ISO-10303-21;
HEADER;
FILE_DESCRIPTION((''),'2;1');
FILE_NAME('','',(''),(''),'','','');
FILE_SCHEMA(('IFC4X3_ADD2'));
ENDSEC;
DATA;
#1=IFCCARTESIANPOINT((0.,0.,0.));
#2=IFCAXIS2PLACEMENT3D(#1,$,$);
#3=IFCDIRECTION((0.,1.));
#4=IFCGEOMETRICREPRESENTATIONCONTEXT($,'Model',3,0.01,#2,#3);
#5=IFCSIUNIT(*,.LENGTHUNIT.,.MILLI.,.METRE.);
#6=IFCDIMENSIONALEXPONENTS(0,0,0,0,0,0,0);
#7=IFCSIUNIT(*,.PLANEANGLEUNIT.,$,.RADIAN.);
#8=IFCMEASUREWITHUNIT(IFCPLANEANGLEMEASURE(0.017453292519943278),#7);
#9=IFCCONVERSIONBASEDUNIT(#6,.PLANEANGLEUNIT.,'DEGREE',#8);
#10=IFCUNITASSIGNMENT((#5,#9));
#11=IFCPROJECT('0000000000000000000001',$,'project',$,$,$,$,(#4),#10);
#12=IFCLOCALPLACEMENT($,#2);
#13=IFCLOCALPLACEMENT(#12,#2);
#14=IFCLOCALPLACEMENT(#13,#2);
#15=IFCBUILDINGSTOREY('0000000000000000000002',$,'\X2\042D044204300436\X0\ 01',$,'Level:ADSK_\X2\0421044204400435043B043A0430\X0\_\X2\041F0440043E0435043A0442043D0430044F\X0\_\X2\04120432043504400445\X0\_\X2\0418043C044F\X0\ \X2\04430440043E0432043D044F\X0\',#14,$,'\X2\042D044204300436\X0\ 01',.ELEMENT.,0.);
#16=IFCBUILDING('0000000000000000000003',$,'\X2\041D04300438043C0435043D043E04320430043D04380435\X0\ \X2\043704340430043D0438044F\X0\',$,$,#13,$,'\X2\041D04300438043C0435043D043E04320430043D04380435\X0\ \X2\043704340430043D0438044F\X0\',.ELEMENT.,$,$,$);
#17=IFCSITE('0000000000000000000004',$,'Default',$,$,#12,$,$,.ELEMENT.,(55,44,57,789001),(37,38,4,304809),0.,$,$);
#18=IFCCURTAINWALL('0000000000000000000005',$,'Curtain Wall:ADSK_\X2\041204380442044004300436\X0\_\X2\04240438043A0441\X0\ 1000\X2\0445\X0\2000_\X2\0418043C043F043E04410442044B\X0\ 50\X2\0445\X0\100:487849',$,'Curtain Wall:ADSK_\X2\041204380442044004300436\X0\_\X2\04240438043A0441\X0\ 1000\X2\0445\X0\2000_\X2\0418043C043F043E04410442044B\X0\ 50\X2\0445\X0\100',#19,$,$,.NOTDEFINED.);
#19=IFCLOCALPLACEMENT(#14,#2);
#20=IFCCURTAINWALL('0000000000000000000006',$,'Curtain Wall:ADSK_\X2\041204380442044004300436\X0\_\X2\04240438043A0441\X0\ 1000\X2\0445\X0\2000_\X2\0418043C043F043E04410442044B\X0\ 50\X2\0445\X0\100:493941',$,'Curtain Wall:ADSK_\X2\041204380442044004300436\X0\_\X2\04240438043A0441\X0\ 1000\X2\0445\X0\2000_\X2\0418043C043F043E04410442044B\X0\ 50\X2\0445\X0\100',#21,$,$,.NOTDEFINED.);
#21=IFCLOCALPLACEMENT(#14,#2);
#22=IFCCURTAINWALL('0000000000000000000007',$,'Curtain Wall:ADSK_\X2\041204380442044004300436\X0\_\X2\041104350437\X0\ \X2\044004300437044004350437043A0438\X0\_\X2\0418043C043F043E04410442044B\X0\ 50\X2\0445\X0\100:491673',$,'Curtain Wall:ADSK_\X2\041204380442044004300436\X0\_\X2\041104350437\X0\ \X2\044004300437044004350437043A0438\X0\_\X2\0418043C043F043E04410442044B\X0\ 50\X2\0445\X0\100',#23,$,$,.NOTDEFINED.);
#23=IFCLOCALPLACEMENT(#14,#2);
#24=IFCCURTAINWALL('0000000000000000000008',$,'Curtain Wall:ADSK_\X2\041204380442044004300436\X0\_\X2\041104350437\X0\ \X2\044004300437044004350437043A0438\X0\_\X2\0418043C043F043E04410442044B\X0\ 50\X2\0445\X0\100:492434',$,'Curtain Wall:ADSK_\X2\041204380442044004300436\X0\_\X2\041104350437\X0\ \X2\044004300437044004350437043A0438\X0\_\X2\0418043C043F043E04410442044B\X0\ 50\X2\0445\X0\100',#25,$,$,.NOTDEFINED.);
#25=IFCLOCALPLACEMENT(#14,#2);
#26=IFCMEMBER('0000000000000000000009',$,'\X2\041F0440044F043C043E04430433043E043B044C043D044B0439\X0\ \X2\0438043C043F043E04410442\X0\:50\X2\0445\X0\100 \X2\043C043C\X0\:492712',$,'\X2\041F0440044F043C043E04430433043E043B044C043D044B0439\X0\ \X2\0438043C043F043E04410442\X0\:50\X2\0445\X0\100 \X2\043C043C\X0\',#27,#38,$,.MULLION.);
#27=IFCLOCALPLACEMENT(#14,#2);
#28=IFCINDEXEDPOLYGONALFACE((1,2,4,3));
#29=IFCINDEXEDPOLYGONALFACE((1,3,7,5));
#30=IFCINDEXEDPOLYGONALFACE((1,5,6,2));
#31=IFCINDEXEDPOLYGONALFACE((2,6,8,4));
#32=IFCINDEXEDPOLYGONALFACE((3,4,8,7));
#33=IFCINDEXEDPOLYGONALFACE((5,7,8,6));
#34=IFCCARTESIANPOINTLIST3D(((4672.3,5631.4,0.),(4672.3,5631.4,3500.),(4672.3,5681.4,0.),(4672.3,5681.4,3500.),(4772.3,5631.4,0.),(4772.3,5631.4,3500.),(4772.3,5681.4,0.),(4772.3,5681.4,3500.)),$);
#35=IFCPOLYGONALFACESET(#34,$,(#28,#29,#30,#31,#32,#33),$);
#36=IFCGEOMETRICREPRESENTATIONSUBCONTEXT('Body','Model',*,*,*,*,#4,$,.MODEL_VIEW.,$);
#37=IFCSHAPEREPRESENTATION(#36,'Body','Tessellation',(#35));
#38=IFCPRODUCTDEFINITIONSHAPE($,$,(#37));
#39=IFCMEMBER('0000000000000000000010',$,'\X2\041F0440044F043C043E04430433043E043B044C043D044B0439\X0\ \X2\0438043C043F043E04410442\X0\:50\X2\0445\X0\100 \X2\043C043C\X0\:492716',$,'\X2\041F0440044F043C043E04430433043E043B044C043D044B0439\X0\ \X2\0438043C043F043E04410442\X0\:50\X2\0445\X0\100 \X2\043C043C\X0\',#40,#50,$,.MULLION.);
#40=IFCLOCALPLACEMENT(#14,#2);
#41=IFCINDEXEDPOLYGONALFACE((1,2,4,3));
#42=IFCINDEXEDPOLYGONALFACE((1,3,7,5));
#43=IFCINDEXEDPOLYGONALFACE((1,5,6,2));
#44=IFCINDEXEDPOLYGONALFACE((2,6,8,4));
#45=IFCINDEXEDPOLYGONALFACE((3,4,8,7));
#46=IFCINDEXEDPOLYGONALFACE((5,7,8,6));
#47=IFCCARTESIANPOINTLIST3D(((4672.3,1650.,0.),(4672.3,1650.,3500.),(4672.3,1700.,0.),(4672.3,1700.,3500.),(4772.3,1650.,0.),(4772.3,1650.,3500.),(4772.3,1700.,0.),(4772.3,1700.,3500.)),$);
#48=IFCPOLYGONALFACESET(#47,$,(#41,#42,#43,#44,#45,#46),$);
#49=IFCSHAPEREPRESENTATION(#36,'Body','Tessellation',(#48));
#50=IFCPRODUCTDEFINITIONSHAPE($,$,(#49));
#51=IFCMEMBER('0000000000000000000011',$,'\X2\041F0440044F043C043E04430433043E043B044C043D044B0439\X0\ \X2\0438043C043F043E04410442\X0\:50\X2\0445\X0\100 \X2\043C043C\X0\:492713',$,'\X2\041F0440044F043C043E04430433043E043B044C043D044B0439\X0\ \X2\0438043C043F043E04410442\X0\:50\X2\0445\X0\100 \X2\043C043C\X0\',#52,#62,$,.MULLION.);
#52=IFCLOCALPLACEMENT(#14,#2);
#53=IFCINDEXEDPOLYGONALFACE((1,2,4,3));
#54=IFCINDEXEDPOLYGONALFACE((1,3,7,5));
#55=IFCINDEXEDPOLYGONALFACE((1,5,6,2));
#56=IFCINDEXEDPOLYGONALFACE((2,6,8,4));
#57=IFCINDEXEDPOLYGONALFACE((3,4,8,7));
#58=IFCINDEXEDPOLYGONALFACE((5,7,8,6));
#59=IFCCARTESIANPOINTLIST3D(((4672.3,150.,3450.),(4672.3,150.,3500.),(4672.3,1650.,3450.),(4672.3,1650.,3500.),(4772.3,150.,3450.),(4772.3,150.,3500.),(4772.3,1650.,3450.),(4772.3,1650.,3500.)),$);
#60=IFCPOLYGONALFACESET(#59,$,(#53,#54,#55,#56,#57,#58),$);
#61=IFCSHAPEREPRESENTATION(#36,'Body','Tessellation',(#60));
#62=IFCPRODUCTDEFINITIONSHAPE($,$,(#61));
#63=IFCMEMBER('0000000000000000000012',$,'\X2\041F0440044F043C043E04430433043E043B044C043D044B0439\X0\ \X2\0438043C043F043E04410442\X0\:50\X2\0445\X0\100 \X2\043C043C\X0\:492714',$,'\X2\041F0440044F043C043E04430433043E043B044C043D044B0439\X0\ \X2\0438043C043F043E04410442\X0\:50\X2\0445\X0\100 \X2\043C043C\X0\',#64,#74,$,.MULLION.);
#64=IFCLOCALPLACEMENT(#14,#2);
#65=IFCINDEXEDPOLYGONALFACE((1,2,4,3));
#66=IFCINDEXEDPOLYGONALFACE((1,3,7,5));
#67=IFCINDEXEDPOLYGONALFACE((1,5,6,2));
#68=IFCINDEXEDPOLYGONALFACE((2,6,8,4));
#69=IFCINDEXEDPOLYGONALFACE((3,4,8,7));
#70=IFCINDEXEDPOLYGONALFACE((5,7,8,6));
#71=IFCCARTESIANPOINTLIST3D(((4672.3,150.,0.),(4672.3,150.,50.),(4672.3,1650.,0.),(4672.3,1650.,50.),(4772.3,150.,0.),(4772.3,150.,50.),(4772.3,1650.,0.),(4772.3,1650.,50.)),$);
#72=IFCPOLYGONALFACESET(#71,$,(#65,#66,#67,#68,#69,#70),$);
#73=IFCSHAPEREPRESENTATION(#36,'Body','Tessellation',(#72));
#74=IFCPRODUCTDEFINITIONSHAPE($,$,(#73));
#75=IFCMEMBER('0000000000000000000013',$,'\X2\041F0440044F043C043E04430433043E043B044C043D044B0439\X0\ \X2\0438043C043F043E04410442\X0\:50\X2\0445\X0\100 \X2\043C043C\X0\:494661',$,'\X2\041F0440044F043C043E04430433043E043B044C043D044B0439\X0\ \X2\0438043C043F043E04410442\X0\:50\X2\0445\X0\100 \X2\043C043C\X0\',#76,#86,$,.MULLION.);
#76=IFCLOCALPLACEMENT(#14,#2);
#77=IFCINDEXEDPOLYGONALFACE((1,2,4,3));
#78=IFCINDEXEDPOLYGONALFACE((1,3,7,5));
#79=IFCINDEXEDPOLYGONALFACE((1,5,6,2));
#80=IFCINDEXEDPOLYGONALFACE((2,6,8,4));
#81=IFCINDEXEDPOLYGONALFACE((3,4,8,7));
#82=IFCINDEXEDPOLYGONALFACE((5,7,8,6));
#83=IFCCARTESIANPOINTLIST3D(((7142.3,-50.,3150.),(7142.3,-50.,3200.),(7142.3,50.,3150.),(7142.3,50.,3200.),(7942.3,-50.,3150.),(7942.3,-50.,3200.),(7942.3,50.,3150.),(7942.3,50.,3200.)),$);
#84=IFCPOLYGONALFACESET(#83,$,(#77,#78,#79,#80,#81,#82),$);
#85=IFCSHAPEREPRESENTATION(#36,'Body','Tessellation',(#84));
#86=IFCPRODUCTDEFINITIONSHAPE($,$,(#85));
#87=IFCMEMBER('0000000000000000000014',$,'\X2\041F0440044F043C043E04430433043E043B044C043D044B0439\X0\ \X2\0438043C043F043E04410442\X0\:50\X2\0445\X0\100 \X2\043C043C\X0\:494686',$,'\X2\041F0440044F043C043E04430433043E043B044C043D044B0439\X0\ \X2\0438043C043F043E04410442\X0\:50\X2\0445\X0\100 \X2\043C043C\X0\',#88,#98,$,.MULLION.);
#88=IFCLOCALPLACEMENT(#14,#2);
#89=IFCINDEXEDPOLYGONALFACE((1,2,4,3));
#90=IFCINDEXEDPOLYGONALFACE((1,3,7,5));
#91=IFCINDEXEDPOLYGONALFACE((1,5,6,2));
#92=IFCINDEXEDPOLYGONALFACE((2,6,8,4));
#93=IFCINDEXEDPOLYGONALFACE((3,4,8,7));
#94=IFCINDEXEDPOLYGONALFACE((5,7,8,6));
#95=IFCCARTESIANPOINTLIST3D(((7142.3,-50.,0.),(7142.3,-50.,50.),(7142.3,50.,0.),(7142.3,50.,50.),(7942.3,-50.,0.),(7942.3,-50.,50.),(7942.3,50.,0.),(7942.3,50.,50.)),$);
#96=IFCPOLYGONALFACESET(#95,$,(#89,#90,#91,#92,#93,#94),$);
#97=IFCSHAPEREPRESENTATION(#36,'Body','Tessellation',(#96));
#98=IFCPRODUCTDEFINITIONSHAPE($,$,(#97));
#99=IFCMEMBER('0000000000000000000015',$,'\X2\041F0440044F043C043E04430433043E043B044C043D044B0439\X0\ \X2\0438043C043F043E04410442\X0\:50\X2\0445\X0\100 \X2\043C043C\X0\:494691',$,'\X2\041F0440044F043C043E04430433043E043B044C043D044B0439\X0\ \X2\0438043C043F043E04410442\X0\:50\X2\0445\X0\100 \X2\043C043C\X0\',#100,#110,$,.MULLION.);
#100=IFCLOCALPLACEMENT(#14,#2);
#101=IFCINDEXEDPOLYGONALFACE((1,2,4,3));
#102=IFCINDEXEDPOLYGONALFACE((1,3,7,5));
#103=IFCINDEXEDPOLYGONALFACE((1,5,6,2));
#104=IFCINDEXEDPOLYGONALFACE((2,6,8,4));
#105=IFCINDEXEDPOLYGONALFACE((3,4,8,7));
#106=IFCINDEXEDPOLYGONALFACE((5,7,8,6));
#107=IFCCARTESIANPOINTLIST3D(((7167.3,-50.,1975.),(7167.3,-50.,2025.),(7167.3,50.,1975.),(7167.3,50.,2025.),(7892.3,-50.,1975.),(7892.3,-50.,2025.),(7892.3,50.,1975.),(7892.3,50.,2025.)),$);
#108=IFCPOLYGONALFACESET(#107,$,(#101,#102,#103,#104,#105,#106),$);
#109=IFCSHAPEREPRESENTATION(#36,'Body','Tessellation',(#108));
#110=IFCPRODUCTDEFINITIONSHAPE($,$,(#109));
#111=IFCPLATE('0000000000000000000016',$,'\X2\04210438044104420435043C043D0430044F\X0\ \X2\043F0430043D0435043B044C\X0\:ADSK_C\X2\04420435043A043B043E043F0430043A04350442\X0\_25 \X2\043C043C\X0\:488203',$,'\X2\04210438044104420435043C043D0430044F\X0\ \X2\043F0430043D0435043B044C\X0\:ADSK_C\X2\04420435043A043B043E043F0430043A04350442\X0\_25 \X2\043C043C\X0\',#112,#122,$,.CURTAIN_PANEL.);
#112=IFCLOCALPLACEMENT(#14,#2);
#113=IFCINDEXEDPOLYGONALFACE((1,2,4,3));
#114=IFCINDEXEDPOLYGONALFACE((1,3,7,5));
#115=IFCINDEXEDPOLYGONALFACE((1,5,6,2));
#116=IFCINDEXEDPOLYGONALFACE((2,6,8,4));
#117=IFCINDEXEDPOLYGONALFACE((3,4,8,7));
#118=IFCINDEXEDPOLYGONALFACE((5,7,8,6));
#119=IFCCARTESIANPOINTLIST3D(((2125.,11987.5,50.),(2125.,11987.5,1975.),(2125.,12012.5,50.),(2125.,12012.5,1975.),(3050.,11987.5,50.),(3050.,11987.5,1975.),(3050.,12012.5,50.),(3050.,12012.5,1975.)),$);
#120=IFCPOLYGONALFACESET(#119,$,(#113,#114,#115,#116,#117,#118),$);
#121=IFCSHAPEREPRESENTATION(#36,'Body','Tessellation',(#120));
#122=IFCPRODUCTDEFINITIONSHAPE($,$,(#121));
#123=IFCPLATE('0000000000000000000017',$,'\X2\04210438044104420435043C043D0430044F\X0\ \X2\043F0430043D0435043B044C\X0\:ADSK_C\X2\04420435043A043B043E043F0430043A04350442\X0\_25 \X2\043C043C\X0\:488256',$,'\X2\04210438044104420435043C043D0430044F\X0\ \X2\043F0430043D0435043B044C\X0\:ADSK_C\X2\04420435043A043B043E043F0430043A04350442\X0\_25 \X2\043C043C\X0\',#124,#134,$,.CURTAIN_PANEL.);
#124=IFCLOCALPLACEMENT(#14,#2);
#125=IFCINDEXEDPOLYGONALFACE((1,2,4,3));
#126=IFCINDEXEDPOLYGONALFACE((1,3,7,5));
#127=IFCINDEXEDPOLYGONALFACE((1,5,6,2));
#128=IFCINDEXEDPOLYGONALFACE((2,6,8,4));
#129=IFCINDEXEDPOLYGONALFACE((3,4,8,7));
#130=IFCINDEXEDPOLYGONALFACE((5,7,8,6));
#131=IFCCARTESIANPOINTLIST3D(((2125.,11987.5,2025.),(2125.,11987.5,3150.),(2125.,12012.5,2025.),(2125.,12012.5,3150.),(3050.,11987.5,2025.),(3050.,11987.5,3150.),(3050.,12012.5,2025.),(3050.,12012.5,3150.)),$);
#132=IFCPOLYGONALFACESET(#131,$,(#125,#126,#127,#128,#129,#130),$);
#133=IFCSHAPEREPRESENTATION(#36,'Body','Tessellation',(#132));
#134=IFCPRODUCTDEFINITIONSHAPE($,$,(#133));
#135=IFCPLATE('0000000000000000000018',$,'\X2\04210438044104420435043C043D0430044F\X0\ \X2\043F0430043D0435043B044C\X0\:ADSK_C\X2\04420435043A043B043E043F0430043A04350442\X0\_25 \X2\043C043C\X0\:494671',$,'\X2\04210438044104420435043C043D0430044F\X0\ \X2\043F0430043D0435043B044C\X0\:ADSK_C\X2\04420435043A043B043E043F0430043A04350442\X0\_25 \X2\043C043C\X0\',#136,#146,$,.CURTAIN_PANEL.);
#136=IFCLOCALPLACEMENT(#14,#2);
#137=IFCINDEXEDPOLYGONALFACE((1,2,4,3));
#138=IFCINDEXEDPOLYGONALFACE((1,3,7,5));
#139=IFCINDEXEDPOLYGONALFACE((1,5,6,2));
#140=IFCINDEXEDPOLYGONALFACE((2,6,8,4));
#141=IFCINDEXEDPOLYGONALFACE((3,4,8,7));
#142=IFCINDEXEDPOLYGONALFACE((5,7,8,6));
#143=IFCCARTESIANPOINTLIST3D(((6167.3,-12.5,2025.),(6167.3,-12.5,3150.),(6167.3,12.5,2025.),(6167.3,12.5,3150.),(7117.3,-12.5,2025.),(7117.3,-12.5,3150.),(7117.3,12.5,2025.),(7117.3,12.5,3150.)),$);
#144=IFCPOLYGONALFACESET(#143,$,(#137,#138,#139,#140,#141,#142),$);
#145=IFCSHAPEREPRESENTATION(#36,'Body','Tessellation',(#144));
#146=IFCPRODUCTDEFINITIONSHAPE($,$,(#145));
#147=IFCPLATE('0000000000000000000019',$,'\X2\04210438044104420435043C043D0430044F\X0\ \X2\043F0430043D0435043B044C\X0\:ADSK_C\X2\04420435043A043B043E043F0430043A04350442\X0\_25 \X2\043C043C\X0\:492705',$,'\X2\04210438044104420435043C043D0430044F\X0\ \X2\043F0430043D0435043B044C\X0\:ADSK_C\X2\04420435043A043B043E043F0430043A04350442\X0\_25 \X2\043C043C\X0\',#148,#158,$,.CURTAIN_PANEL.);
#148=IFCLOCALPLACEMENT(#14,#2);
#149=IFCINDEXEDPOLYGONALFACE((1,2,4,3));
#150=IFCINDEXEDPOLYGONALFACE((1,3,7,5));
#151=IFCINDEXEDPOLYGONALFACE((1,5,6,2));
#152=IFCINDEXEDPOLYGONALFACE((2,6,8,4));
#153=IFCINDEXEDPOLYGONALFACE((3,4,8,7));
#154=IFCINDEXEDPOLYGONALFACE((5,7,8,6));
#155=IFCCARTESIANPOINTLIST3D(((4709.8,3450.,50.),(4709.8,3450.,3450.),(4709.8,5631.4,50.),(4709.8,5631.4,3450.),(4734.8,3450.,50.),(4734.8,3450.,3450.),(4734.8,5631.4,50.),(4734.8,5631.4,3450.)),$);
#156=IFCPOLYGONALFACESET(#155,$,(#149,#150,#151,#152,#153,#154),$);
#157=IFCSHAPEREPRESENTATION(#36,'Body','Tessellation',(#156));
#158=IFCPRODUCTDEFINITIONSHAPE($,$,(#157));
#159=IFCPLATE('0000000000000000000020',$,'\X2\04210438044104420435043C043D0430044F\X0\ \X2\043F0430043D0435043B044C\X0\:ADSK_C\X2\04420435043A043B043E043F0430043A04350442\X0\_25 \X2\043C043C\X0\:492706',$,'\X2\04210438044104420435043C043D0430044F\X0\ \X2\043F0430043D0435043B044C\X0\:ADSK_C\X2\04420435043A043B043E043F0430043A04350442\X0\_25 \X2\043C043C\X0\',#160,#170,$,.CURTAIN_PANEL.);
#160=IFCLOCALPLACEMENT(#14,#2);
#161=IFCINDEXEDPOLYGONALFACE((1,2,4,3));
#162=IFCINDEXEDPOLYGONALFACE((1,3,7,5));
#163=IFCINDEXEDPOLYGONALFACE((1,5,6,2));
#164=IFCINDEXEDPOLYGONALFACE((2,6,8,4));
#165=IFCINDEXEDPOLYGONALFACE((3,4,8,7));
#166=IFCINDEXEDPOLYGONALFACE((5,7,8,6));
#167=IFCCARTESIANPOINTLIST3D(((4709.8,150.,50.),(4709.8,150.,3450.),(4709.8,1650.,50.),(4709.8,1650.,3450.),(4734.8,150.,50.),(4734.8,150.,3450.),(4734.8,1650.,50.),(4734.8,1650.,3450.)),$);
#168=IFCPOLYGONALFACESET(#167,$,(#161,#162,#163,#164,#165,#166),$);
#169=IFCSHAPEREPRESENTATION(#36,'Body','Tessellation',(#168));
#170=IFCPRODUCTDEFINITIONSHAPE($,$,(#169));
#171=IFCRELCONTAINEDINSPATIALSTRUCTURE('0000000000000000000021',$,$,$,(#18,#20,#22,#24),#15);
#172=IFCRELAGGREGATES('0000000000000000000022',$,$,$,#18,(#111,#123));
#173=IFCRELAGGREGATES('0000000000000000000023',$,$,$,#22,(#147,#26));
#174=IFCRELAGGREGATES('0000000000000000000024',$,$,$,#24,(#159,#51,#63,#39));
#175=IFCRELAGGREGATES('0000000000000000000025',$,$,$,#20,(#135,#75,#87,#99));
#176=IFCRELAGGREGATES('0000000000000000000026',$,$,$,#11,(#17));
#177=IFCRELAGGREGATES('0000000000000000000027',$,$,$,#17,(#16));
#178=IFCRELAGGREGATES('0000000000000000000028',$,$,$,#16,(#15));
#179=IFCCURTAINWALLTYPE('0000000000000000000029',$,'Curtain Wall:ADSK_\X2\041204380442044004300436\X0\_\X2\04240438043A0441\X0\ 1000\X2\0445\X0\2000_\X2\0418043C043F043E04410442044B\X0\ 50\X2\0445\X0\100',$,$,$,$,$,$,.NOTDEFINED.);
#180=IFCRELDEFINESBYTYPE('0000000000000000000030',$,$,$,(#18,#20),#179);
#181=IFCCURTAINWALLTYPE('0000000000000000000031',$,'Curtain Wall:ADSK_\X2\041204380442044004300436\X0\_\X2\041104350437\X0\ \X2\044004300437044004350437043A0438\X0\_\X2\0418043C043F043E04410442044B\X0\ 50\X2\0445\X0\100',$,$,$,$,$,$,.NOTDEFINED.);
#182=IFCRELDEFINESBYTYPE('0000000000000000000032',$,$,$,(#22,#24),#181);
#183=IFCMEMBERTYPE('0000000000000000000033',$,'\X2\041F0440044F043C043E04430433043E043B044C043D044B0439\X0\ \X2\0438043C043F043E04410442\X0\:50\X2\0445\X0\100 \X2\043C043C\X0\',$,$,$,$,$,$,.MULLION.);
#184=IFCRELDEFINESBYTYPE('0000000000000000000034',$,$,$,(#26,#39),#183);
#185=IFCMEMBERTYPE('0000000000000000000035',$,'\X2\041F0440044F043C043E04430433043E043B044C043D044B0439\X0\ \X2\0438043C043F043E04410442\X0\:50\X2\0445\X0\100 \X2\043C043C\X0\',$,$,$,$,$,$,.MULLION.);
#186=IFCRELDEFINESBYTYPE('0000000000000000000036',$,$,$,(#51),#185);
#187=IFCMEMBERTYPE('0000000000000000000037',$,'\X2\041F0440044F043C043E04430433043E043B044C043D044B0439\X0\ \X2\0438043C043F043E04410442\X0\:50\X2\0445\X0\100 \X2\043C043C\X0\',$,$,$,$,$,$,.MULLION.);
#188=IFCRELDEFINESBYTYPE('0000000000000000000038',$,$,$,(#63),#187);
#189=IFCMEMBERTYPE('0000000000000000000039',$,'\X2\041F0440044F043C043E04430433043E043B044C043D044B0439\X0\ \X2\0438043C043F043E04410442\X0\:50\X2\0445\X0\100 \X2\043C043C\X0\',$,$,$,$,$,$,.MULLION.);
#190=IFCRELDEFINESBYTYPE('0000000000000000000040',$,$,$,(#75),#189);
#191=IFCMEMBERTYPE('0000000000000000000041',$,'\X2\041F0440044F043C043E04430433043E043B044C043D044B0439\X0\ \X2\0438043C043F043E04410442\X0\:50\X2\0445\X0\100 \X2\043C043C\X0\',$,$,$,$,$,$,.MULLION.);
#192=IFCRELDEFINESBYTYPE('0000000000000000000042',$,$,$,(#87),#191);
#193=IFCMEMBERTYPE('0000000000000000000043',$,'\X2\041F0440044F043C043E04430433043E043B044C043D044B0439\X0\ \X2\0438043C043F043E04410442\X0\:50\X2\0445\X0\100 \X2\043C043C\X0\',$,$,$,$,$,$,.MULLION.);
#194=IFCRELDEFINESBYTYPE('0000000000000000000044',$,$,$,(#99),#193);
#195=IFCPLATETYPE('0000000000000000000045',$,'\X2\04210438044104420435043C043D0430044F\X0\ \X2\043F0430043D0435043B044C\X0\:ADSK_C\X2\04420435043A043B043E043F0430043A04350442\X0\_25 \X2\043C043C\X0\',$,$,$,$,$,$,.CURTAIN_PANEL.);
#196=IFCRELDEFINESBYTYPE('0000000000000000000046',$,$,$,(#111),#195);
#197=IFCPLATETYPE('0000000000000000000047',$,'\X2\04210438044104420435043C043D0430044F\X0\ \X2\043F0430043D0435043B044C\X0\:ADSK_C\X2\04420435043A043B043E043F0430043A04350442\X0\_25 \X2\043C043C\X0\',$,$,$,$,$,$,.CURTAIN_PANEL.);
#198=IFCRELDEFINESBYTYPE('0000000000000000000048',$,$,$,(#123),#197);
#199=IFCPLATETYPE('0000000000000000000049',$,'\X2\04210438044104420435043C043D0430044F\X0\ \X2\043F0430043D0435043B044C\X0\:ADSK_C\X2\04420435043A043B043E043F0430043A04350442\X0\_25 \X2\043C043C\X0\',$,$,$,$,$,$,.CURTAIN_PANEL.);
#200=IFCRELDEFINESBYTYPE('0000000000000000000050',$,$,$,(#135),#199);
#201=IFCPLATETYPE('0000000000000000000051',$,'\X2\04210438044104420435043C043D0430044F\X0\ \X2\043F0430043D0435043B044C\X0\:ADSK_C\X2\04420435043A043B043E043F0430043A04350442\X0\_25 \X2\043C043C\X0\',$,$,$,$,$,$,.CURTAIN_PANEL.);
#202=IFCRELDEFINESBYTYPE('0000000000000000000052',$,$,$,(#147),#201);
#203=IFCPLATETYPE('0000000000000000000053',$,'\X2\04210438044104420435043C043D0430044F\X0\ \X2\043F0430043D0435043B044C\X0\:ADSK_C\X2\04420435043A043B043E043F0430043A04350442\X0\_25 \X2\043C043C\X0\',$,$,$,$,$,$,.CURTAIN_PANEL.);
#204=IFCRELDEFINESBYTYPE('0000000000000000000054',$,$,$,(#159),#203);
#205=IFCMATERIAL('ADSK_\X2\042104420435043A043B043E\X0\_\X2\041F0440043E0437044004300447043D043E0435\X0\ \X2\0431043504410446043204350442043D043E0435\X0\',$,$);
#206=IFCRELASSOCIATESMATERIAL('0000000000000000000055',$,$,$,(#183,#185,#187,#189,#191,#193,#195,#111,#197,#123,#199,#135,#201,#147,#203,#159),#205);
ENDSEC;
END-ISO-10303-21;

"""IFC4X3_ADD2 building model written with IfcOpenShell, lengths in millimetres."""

from ifc_helpers import new_model, entity, si_unit, converted_unit, direction, frame, frame_2d, origin, origin_2d_with_axis, place, context, subcontext, project, spatial, rectangle, extrude, source, transform, mapped, material, material_profile, profile_set, type_object, type_shapes, element, aggregate, save


model = new_model("IFC4X3_ADD2")

# Units and contexts
model_context = context("Model", 3, precision=0.01, world=origin(), true_north=direction((0.0, 1.0)))
body_context = subcontext(model_context, "Body", "Model", "MODEL_VIEW")
ifc_project = project(units=[si_unit("LENGTHUNIT", "METRE", prefix="MILLI"), converted_unit("PLANEANGLEUNIT", "DEGREE", entity("IfcPlaneAngleMeasure", 0.017453292519943278), si_unit("PLANEANGLEUNIT", "RADIAN"), dimensions=[0, 0, 0, 0, 0, 0, 0])], contexts=[model_context])

# Site, building, storey
site_placement = place(None, origin())
site = spatial("IfcSite", under=ifc_project, at=site_placement, Name="Default", CompositionType="ELEMENT", RefLatitude=(55, 44, 57, 789001), RefLongitude=(37, 38, 4, 304809), RefElevation=0.0)
building_placement = place(site_placement, origin())
building = spatial("IfcBuilding", under=site, at=building_placement, Name="Наименование здания", LongName="Наименование здания", CompositionType="ELEMENT")
storey_placement = place(building_placement, origin())
storey = spatial("IfcBuildingStorey", under=building, at=storey_placement, Name="Этаж 01", ObjectType="Level:ADSK_Стрелка_Проектная_Вверх_Имя уровня", LongName="Этаж 01", CompositionType="ELEMENT", Elevation=0.0)

# Curtain wall
curtain_wall_type_1 = type_object("IfcCurtainWallType", Name="Curtain Wall:ADSK_Витраж_Фикс 1000х2000_Импосты 50х100", PredefinedType="NOTDEFINED")
curtain_wall_1_placement = place(storey_placement, origin())
curtain_wall_1 = element("IfcCurtainWall", 1, at=curtain_wall_1_placement, inside=storey, type_object=curtain_wall_type_1, Name="Curtain Wall:ADSK_Витраж_Фикс 1000х2000_Импосты 50х100:487849", ObjectType="Curtain Wall:ADSK_Витраж_Фикс 1000х2000_Импосты 50х100", PredefinedType="NOTDEFINED")
ifc_material_1 = material(Name="ADSK_Стекло_Прозрачное бесцветное")
ifc_material_profile = material_profile(ifc_material_1, rectangle(XDim=50.0, YDim=100.0, at=frame_2d((0.0, 0.0), x_axis=(1.0, 0.0))), Name="50х100 мм")
ifc_profile_set = profile_set([ifc_material_profile], Name="50х100 мм")

# Curtain wall
curtain_wall_2_placement = place(storey_placement, origin())
curtain_wall_2 = element("IfcCurtainWall", 2, at=curtain_wall_2_placement, inside=storey, type_object=curtain_wall_type_1, Name="Curtain Wall:ADSK_Витраж_Фикс 1000х2000_Импосты 50х100:493941", ObjectType="Curtain Wall:ADSK_Витраж_Фикс 1000х2000_Импосты 50х100", PredefinedType="NOTDEFINED")

# Curtain wall
curtain_wall_type_2 = type_object("IfcCurtainWallType", Name="Curtain Wall:ADSK_Витраж_Без разрезки_Импосты 50х100", PredefinedType="NOTDEFINED")
curtain_wall_3_placement = place(storey_placement, origin())
curtain_wall_3 = element("IfcCurtainWall", 3, at=curtain_wall_3_placement, inside=storey, type_object=curtain_wall_type_2, Name="Curtain Wall:ADSK_Витраж_Без разрезки_Импосты 50х100:491673", ObjectType="Curtain Wall:ADSK_Витраж_Без разрезки_Импосты 50х100", PredefinedType="NOTDEFINED")

# Curtain wall
curtain_wall_4_placement = place(storey_placement, origin())
curtain_wall_4 = element("IfcCurtainWall", 4, at=curtain_wall_4_placement, inside=storey, type_object=curtain_wall_type_2, Name="Curtain Wall:ADSK_Витраж_Без разрезки_Импосты 50х100:492434", ObjectType="Curtain Wall:ADSK_Витраж_Без разрезки_Импосты 50х100", PredefinedType="NOTDEFINED")

# Members
member_type_1 = type_object("IfcMemberType", Name="Прямоугольный импост:50х100 мм", PredefinedType="MULLION", material=ifc_profile_set)
shared_shape_1 = source(origin(), body_context, "Body", "SweptSolid", [
    extrude(rectangle(XDim=50.0, YDim=100.0, at=frame_2d((0.0, 0.0), x_axis=(1.0, 0.0))), frame((-25.0, 0.0, -3500.0), z_axis=(0.0, 0.0, 1.0), x_axis=(-1.0, 0.0, 0.0)), (0.0, 0.0, 1.0), 3500.0),
])
type_shapes(member_type_1, [shared_shape_1])
member_1_placement = place(curtain_wall_3_placement, frame((4722.3, 5681.4, 3500.0), z_axis=(0.0, 0.0, 1.0), x_axis=(0.0, 1.0, 0.0)))
member_1 = element("IfcMember", 5, at=member_1_placement, type_object=member_type_1, Name="Прямоугольный импост:50х100 мм:492712", ObjectType="Прямоугольный импост:50х100 мм", PredefinedType="MULLION", context=body_context, shape_type="MappedRepresentation", body=[
    mapped(shared_shape_1, transform((0.0, 0.0, 0.0), scale=1.0)),
])
member_2_placement = place(curtain_wall_4_placement, frame((4722.3, 1700.0, 3500.0), z_axis=(0.0, 0.0, 1.0), x_axis=(0.0, 1.0, 0.0)))
member_2 = element("IfcMember", 6, at=member_2_placement, type_object=member_type_1, Name="Прямоугольный импост:50х100 мм:492716", ObjectType="Прямоугольный импост:50х100 мм", PredefinedType="MULLION", context=body_context, shape_type="MappedRepresentation", body=[
    mapped(shared_shape_1, transform((0.0, 0.0, 0.0), scale=1.0)),
])
member_type_2 = type_object("IfcMemberType", Name="Прямоугольный импост:50х100 мм", PredefinedType="MULLION", material=ifc_profile_set)
shared_shape_2 = source(origin(), body_context, "Body", "SweptSolid", [
    extrude(rectangle(XDim=50.0, YDim=100.0, at=origin_2d_with_axis()), frame((-25.0, 0.0, -1500.0), z_axis=(0.0, 0.0, 1.0), x_axis=(-1.0, 0.0, 0.0)), (0.0, 0.0, 1.0), 1500.0),
])
type_shapes(member_type_2, [shared_shape_2])
member_3_placement = place(curtain_wall_4_placement, frame((4722.3, 150.0, 3500.0), z_axis=(0.0, -1.0, 0.0), x_axis=(0.0, 0.0, 1.0)))
member_3 = element("IfcMember", 7, at=member_3_placement, type_object=member_type_2, Name="Прямоугольный импост:50х100 мм:492713", ObjectType="Прямоугольный импост:50х100 мм", PredefinedType="MULLION", context=body_context, shape_type="MappedRepresentation", body=[
    mapped(shared_shape_2, transform((0.0, 0.0, 0.0), scale=1.0)),
])
member_type_3 = type_object("IfcMemberType", Name="Прямоугольный импост:50х100 мм", PredefinedType="MULLION", material=ifc_profile_set)
shared_shape_3 = source(origin(), body_context, "Body", "SweptSolid", [
    extrude(rectangle(XDim=50.0, YDim=100.0, at=origin_2d_with_axis()), frame((-25.0, 0.0, -1500.0), z_axis=(0.0, 0.0, 1.0), x_axis=(-1.0, 0.0, 0.0)), (0.0, 0.0, 1.0), 1500.0),
])
type_shapes(member_type_3, [shared_shape_3])
member_4_placement = place(curtain_wall_4_placement, frame((4722.3, 1650.0, 0.0), z_axis=(0.0, 1.0, 0.0), x_axis=(0.0, 0.0, -1.0)))
member_4 = element("IfcMember", 8, at=member_4_placement, type_object=member_type_3, Name="Прямоугольный импост:50х100 мм:492714", ObjectType="Прямоугольный импост:50х100 мм", PredefinedType="MULLION", context=body_context, shape_type="MappedRepresentation", body=[
    mapped(shared_shape_3, transform((0.0, 0.0, 0.0), scale=1.0)),
])
member_type_4 = type_object("IfcMemberType", Name="Прямоугольный импост:50х100 мм", PredefinedType="MULLION", material=ifc_profile_set)
shared_shape_4 = source(origin(), body_context, "Body", "SweptSolid", [
    extrude(rectangle(XDim=50.0, YDim=100.0, at=frame_2d((0.0, 0.0), x_axis=(1.0, 0.0))), frame((-25.0, 0.0, -800.0), z_axis=(0.0, 0.0, 1.0), x_axis=(-1.0, 0.0, 0.0)), (0.0, 0.0, 1.0), 800.0),
])
type_shapes(member_type_4, [shared_shape_4])
member_5_placement = place(curtain_wall_2_placement, frame((7942.3, 0.0, 3200.0), z_axis=(1.0, 0.0, 0.0), x_axis=(0.0, 0.0, 1.0)))
member_5 = element("IfcMember", 9, at=member_5_placement, type_object=member_type_4, Name="Прямоугольный импост:50х100 мм:494661", ObjectType="Прямоугольный импост:50х100 мм", PredefinedType="MULLION", context=body_context, shape_type="MappedRepresentation", body=[
    mapped(shared_shape_4, transform((0.0, 0.0, 0.0), scale=1.0)),
])
member_type_5 = type_object("IfcMemberType", Name="Прямоугольный импост:50х100 мм", PredefinedType="MULLION", material=ifc_profile_set)
shared_shape_5 = source(origin(), body_context, "Body", "SweptSolid", [
    extrude(rectangle(XDim=50.0, YDim=100.0, at=frame_2d((0.0, 0.0), x_axis=(1.0, 0.0))), frame((-25.0, 0.0, -800.0), z_axis=(0.0, 0.0, 1.0), x_axis=(-1.0, 0.0, 0.0)), (0.0, 0.0, 1.0), 800.0),
])
type_shapes(member_type_5, [shared_shape_5])
member_6_placement = place(curtain_wall_2_placement, frame((7142.3, 0.0, 0.0), z_axis=(-1.0, 0.0, 0.0), x_axis=(0.0, 0.0, -1.0)))
member_6 = element("IfcMember", 10, at=member_6_placement, type_object=member_type_5, Name="Прямоугольный импост:50х100 мм:494686", ObjectType="Прямоугольный импост:50х100 мм", PredefinedType="MULLION", context=body_context, shape_type="MappedRepresentation", body=[
    mapped(shared_shape_5, transform((0.0, 0.0, 0.0), scale=1.0)),
])
member_type_6 = type_object("IfcMemberType", Name="Прямоугольный импост:50х100 мм", PredefinedType="MULLION", material=ifc_profile_set)
shared_shape_6 = source(origin(), body_context, "Body", "SweptSolid", [
    extrude(rectangle(XDim=50.0, YDim=100.0, at=frame_2d((0.0, 0.0), x_axis=(1.0, 0.0))), frame((0.0, 0.0, -725.0), z_axis=(0.0, 0.0, 1.0), x_axis=(-1.0, 0.0, 0.0)), (0.0, 0.0, 1.0), 725.0),
])
type_shapes(member_type_6, [shared_shape_6])
member_7_placement = place(curtain_wall_2_placement, frame((7892.3, 0.0, 2000.0), z_axis=(1.0, 0.0, 0.0), x_axis=(0.0, 0.0, 1.0)))
member_7 = element("IfcMember", 11, at=member_7_placement, type_object=member_type_6, Name="Прямоугольный импост:50х100 мм:494691", ObjectType="Прямоугольный импост:50х100 мм", PredefinedType="MULLION", context=body_context, shape_type="MappedRepresentation", body=[
    mapped(shared_shape_6, transform((0.0, 0.0, 0.0), scale=1.0)),
])

# Plates
plate_type_1 = type_object("IfcPlateType", Name="Системная панель:ADSK_Cтеклопакет_25 мм", PredefinedType="CURTAIN_PANEL", material=ifc_material_1)
shared_shape_7 = source(origin(), body_context, "Body", "SweptSolid", [
    extrude(rectangle(XDim=25.0, YDim=925.0, at=origin_2d_with_axis()), frame((0.0, 0.0, 0.0), z_axis=(0.0, 0.0, 1.0), x_axis=(0.0, 1.0, 0.0)), (0.0, 0.0, 1.0), 1925.0),
])
type_shapes(plate_type_1, [shared_shape_7])
plate_1_placement = place(curtain_wall_1_placement, frame((2587.5, 12000.0, 50.0), z_axis=(0.0, 0.0, 1.0), x_axis=(-1.0, 0.0, 0.0)))
plate_1 = element("IfcPlate", 12, at=plate_1_placement, type_object=plate_type_1, material=ifc_material_1, Name="Системная панель:ADSK_Cтеклопакет_25 мм:488203", ObjectType="Системная панель:ADSK_Cтеклопакет_25 мм", PredefinedType="CURTAIN_PANEL", context=body_context, shape_type="MappedRepresentation", body=[
    mapped(shared_shape_7, transform((0.0, 0.0, 0.0), scale=1.0)),
])
plate_type_2 = type_object("IfcPlateType", Name="Системная панель:ADSK_Cтеклопакет_25 мм", PredefinedType="CURTAIN_PANEL", material=ifc_material_1)
shared_shape_8 = source(origin(), body_context, "Body", "SweptSolid", [
    extrude(rectangle(XDim=25.0, YDim=925.0, at=origin_2d_with_axis()), frame((0.0, 0.0, 0.0), z_axis=(0.0, 0.0, 1.0), x_axis=(0.0, 1.0, 0.0)), (0.0, 0.0, 1.0), 1125.0),
])
type_shapes(plate_type_2, [shared_shape_8])
plate_2_placement = place(curtain_wall_1_placement, frame((2587.5, 12000.0, 2025.0), z_axis=(0.0, 0.0, 1.0), x_axis=(-1.0, 0.0, 0.0)))
plate_2 = element("IfcPlate", 13, at=plate_2_placement, type_object=plate_type_2, material=ifc_material_1, Name="Системная панель:ADSK_Cтеклопакет_25 мм:488256", ObjectType="Системная панель:ADSK_Cтеклопакет_25 мм", PredefinedType="CURTAIN_PANEL", context=body_context, shape_type="MappedRepresentation", body=[
    mapped(shared_shape_8, transform((0.0, 0.0, 0.0), scale=1.0)),
])
aggregate(curtain_wall_1, [plate_1, plate_2])
plate_type_3 = type_object("IfcPlateType", Name="Системная панель:ADSK_Cтеклопакет_25 мм", PredefinedType="CURTAIN_PANEL", material=ifc_material_1)
shared_shape_9 = source(origin(), body_context, "Body", "SweptSolid", [
    extrude(rectangle(XDim=25.0, YDim=950.0, at=origin_2d_with_axis()), frame((0.0, 0.0, 0.0), z_axis=(0.0, 0.0, 1.0), x_axis=(0.0, 1.0, 0.0)), (0.0, 0.0, 1.0), 1125.0),
])
type_shapes(plate_type_3, [shared_shape_9])
plate_3_placement = place(curtain_wall_2_placement, frame((6642.3, 0.0, 2025.0)))
plate_3 = element("IfcPlate", 14, at=plate_3_placement, type_object=plate_type_3, material=ifc_material_1, Name="Системная панель:ADSK_Cтеклопакет_25 мм:494671", ObjectType="Системная панель:ADSK_Cтеклопакет_25 мм", PredefinedType="CURTAIN_PANEL", context=body_context, shape_type="MappedRepresentation", body=[
    mapped(shared_shape_9, transform((0.0, 0.0, 0.0), scale=1.0)),
])
plate_type_4 = type_object("IfcPlateType", Name="Системная панель:ADSK_Cтеклопакет_25 мм", PredefinedType="CURTAIN_PANEL", material=ifc_material_1)
shared_shape_10 = source(origin(), body_context, "Body", "SweptSolid", [
    extrude(rectangle(XDim=25.0, YDim=2181.4, at=origin_2d_with_axis()), frame((0.0, 0.0, 0.0), z_axis=(0.0, 0.0, 1.0), x_axis=(0.0, 1.0, 0.0)), (0.0, 0.0, 1.0), 3400.0),
])
type_shapes(plate_type_4, [shared_shape_10])
plate_4_placement = place(curtain_wall_3_placement, frame((4722.3, 4540.7, 50.0), z_axis=(0.0, 0.0, 1.0), x_axis=(0.0, -1.0, 0.0)))
plate_4 = element("IfcPlate", 15, at=plate_4_placement, type_object=plate_type_4, material=ifc_material_1, Name="Системная панель:ADSK_Cтеклопакет_25 мм:492705", ObjectType="Системная панель:ADSK_Cтеклопакет_25 мм", PredefinedType="CURTAIN_PANEL", context=body_context, shape_type="MappedRepresentation", body=[
    mapped(shared_shape_10, transform((0.0, 0.0, 0.0), scale=1.0)),
])
aggregate(curtain_wall_3, [plate_4, member_1])
plate_type_5 = type_object("IfcPlateType", Name="Системная панель:ADSK_Cтеклопакет_25 мм", PredefinedType="CURTAIN_PANEL", material=ifc_material_1)
shared_shape_11 = source(origin(), body_context, "Body", "SweptSolid", [
    extrude(rectangle(XDim=25.0, YDim=1500.0, at=origin_2d_with_axis()), frame((0.0, 0.0, 0.0), z_axis=(0.0, 0.0, 1.0), x_axis=(0.0, 1.0, 0.0)), (0.0, 0.0, 1.0), 3400.0),
])
type_shapes(plate_type_5, [shared_shape_11])
plate_5_placement = place(curtain_wall_4_placement, frame((4722.3, 900.0, 50.0), z_axis=(0.0, 0.0, 1.0), x_axis=(0.0, -1.0, 0.0)))
plate_5 = element("IfcPlate", 16, at=plate_5_placement, type_object=plate_type_5, material=ifc_material_1, Name="Системная панель:ADSK_Cтеклопакет_25 мм:492706", ObjectType="Системная панель:ADSK_Cтеклопакет_25 мм", PredefinedType="CURTAIN_PANEL", context=body_context, shape_type="MappedRepresentation", body=[
    mapped(shared_shape_11, transform((0.0, 0.0, 0.0), scale=1.0)),
])
aggregate(curtain_wall_4, [plate_5, member_3, member_4, member_2])
aggregate(curtain_wall_2, [plate_3, member_5, member_6, member_7])

save(model, "model.ifc")
